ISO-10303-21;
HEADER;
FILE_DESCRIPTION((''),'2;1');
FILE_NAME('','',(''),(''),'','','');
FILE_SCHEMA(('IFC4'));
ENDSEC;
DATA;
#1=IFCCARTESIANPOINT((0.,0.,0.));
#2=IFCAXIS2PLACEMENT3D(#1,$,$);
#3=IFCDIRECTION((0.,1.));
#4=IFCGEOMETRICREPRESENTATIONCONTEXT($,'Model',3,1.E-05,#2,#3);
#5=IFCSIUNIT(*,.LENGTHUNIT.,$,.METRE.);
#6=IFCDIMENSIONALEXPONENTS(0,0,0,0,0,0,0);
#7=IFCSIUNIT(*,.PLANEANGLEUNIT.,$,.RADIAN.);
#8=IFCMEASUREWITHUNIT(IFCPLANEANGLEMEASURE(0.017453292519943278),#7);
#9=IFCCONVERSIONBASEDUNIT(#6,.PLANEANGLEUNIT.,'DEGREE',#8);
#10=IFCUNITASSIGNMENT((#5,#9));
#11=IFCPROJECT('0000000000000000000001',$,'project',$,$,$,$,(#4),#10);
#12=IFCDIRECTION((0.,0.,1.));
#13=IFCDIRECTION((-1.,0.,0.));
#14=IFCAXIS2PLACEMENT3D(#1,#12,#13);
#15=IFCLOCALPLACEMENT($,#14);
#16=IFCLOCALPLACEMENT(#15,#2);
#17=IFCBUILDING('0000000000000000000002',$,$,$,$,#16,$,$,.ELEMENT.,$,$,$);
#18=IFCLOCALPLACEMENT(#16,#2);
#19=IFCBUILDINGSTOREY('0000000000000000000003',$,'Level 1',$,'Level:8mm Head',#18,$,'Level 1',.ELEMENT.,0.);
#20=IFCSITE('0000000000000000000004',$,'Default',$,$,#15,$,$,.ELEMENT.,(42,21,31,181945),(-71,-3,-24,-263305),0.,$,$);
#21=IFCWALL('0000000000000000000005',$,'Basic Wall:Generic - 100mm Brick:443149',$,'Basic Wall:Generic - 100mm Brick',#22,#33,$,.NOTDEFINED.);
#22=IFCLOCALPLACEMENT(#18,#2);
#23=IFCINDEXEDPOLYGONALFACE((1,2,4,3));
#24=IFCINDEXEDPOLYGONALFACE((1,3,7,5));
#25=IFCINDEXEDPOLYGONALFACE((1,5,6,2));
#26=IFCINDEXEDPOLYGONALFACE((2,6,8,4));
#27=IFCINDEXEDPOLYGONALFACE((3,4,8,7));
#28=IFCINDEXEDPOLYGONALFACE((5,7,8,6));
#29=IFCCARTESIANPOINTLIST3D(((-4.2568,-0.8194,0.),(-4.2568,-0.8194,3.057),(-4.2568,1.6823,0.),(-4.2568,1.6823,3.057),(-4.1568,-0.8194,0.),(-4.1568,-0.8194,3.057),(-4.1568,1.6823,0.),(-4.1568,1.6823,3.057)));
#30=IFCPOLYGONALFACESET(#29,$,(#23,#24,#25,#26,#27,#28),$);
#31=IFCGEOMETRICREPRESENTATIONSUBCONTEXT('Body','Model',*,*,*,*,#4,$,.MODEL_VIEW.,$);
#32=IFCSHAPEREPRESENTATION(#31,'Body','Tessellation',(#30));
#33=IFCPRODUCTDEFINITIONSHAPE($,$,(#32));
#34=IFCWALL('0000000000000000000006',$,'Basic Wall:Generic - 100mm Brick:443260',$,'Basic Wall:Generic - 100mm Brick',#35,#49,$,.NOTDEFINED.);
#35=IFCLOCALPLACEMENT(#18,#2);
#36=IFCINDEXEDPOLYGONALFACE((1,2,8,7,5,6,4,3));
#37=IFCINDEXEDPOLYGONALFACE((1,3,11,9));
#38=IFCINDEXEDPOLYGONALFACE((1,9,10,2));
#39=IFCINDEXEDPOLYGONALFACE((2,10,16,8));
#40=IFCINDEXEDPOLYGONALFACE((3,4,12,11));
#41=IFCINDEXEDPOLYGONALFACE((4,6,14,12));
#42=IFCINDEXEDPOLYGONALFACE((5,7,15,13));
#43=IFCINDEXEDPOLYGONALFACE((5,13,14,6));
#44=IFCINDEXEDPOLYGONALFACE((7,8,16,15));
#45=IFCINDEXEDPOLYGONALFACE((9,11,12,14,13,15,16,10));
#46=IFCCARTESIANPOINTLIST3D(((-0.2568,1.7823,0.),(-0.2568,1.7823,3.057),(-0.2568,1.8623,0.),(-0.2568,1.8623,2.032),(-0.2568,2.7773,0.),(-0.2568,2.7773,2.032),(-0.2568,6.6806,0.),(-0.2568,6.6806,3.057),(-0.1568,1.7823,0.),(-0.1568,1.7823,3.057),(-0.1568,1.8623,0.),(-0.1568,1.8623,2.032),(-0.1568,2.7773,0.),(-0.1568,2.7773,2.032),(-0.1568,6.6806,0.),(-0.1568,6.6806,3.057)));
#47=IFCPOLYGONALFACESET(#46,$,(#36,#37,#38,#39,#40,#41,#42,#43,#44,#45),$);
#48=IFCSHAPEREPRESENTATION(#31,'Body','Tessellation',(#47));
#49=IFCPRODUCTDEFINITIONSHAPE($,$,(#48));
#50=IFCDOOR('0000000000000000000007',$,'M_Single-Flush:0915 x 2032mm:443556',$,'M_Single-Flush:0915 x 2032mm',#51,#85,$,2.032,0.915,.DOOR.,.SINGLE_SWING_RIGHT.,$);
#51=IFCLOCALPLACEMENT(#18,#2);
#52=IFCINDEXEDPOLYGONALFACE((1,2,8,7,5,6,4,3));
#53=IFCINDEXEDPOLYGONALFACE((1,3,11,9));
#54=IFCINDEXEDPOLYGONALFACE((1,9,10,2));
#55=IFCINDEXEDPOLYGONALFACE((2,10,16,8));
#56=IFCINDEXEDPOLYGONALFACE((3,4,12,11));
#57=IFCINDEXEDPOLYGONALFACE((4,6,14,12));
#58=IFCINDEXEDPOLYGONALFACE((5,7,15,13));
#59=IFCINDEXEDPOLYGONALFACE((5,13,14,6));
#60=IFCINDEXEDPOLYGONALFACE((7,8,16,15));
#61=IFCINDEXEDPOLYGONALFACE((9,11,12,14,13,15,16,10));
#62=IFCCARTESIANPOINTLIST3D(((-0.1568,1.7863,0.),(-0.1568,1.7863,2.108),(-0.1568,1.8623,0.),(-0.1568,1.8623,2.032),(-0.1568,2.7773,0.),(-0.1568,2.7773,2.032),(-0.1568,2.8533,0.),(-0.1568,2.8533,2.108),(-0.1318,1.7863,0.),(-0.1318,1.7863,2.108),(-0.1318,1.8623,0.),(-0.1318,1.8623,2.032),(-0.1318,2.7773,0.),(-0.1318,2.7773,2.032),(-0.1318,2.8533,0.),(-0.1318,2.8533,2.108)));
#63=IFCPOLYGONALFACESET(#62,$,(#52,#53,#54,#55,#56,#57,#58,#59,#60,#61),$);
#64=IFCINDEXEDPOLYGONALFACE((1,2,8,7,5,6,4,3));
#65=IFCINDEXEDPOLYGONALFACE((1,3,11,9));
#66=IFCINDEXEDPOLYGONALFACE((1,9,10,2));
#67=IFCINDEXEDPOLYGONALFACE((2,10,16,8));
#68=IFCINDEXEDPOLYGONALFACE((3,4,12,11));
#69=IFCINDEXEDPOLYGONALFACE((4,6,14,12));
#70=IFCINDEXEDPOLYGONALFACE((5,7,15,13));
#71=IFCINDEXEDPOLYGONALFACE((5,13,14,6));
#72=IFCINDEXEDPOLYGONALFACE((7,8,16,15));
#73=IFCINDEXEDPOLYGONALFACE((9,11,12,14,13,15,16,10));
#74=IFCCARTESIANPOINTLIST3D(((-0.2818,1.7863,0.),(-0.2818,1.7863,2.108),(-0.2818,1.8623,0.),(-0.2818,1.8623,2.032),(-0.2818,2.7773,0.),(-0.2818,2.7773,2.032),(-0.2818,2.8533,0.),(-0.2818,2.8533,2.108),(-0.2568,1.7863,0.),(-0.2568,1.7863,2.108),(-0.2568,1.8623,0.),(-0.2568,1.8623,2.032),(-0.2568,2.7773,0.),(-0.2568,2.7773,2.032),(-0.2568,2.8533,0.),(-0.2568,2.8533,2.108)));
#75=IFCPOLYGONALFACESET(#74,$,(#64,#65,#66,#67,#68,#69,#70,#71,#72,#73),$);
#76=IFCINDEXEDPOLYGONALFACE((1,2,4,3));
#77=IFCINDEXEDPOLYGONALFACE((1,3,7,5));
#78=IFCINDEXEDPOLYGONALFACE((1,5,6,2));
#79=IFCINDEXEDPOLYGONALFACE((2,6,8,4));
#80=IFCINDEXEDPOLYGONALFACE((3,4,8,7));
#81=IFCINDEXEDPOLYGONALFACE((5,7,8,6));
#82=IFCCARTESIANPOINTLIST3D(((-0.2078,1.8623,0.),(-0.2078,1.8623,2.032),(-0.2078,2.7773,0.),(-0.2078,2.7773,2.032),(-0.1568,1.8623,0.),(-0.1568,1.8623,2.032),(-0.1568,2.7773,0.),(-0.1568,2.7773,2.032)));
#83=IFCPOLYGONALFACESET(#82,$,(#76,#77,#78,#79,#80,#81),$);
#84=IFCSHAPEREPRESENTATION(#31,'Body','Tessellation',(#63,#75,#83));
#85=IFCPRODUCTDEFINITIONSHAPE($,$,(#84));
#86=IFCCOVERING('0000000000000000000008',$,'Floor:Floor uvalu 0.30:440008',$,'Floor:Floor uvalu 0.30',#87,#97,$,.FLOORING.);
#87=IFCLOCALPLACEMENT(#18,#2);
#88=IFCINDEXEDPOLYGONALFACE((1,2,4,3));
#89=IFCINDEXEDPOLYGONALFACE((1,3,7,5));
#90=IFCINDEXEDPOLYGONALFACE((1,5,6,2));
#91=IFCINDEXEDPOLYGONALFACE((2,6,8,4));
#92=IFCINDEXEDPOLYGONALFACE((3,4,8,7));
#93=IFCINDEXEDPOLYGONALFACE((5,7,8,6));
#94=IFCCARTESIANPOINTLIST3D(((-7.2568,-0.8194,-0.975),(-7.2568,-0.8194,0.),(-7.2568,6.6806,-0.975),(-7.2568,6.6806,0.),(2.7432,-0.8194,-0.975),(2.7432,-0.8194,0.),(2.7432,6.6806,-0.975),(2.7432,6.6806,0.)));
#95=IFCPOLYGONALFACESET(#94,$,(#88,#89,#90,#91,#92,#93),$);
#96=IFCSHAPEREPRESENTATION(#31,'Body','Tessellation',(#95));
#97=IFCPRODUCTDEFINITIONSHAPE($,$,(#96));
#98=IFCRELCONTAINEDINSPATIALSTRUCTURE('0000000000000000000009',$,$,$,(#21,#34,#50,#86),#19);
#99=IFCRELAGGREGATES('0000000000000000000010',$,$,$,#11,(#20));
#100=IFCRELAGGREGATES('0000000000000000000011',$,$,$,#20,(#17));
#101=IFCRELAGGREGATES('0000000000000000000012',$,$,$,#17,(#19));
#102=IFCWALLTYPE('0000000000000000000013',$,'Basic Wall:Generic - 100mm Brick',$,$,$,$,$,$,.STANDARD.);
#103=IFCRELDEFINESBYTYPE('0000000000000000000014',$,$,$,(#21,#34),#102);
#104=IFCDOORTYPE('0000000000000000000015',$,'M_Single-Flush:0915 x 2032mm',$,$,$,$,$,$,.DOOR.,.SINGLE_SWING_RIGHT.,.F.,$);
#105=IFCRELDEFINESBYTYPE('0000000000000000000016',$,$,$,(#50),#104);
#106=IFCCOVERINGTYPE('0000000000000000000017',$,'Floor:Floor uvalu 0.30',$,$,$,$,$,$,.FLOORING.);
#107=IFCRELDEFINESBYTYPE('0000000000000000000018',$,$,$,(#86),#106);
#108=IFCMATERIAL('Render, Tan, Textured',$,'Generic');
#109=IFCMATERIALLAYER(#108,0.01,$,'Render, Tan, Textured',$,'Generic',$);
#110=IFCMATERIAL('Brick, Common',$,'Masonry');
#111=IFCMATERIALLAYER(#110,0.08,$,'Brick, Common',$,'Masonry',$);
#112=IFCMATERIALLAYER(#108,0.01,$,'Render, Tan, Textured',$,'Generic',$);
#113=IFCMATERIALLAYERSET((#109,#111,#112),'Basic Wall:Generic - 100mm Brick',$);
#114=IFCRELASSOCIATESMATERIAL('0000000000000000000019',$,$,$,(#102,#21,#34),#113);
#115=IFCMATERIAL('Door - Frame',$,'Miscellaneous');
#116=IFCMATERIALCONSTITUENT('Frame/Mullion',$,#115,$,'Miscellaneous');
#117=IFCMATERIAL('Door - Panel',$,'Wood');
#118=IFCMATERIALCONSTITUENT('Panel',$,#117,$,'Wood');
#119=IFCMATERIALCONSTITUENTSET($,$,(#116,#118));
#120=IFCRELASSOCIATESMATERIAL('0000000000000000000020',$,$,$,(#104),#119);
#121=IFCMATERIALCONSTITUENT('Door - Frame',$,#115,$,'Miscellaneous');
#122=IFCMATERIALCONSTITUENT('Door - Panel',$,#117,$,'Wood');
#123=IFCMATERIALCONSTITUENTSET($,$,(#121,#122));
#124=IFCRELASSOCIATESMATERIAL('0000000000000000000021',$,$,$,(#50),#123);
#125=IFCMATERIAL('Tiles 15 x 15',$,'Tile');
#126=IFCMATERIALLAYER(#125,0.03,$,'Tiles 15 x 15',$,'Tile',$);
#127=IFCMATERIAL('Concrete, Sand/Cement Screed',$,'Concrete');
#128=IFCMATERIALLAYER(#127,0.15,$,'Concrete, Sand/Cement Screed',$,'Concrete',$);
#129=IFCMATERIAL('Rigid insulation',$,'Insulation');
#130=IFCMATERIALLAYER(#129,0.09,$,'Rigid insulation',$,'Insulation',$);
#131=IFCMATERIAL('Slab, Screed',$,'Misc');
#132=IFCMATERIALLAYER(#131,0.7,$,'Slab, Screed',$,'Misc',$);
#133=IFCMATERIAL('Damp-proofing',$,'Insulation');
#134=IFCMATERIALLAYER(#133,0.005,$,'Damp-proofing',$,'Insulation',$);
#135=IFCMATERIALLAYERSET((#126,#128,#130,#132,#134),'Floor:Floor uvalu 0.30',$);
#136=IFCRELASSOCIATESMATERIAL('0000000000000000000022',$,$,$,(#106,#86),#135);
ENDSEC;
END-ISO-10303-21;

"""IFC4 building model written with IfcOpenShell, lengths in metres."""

from ifc_helpers import new_model, entity, si_unit, converted_unit, direction, frame, frame_2d, origin, origin_2d_with_axis, place, context, subcontext, project, spatial, polyline, rectangle, outline, extrude, source, transform, mapped, material, layer, layer_set, layer_usage, constituent, constituent_set, type_object, type_shapes, element, fill, save


model = new_model("IFC4")

# Units and contexts
model_context = context("Model", 3, precision=1e-05, world=origin(), true_north=direction((0.0, 1.0)))
body_context = subcontext(model_context, "Body", "Model", "MODEL_VIEW")
ifc_project = project(units=[si_unit("LENGTHUNIT", "METRE"), converted_unit("PLANEANGLEUNIT", "DEGREE", entity("IfcPlaneAngleMeasure", 0.017453292519943278), si_unit("PLANEANGLEUNIT", "RADIAN"), dimensions=[0, 0, 0, 0, 0, 0, 0])], contexts=[model_context])

# Site, building, storey
site_placement = place(None, frame((0.0, 0.0, 0.0), z_axis=(0.0, 0.0, 1.0), x_axis=(-1.0, 0.0, 0.0)))
site = spatial("IfcSite", under=ifc_project, at=site_placement, Name="Default", CompositionType="ELEMENT", RefLatitude=(42, 21, 31, 181945), RefLongitude=(-71, -3, -24, -263305), RefElevation=0.0)
building_placement = place(site_placement, origin())
building = spatial("IfcBuilding", under=site, at=building_placement, CompositionType="ELEMENT")
storey_placement = place(building_placement, origin())
storey = spatial("IfcBuildingStorey", under=building, at=storey_placement, Name="Level 1", ObjectType="Level:8mm Head", LongName="Level 1", CompositionType="ELEMENT", Elevation=0.0)

# Shared definitions
ifc_material_1 = material(Name="Rigid insulation", Category="Insulation")
ifc_material_2 = material(Name="Brick, Common", Category="Masonry")

# Shared definitions
ifc_material_3 = material(Name="Render, Tan, Textured", Category="Generic")
ifc_layer_1 = layer(ifc_material_3, 0.01, Name="Render, Tan, Textured", Category="Generic")
ifc_layer_2 = layer(ifc_material_2, 0.08, Name="Brick, Common", Category="Masonry")
ifc_layer_3 = layer(ifc_material_3, 0.01, Name="Render, Tan, Textured", Category="Generic")
ifc_layer_set_1 = layer_set([ifc_layer_1, ifc_layer_2, ifc_layer_3], Name="Basic Wall:Generic - 100mm Brick")
ifc_layer_usage_1 = layer_usage(ifc_layer_set_1, "AXIS2", "NEGATIVE", 0.05)
wall_type_1 = type_object("IfcWallType", Name="Basic Wall:Generic - 100mm Brick", PredefinedType="STANDARD", material=ifc_layer_set_1)
ifc_material_4 = material(Name="Door - Frame", Category="Miscellaneous")
ifc_material_5 = material(Name="Door - Panel", Category="Wood")
ifc_constituent_1 = constituent(ifc_material_4, Name="Frame/Mullion", Category="Miscellaneous")
ifc_constituent_2 = constituent(ifc_material_5, Name="Panel", Category="Wood")
ifc_constituent_set_1 = constituent_set(constituents=[ifc_constituent_1, ifc_constituent_2])
door_type_1 = type_object("IfcDoorType", Name="M_Single-Flush:0915 x 2032mm", OperationType="SINGLE_SWING_RIGHT", ParameterTakesPrecedence=False, PredefinedType="DOOR", material=ifc_constituent_set_1)
shared_shape_1 = source(origin(), body_context, "Body", "SweptSolid", [
    extrude(outline(polyline([(-0.5335, -1.073), (0.5335, -1.073), (0.5335, 1.035), (0.4575, 1.035), (0.4575, -0.997), (-0.4575, -0.997), (-0.4575, 1.035), (-0.5335, 1.035), (-0.5335, -1.073)])), frame((0.4575, 0.1, 1.035), z_axis=(0.0, 1.0, 0.0), x_axis=(1.0, 0.0, 0.0)), (0.0, 0.0, 1.0), 0.025),
    extrude(outline(polyline([(-1.073, -0.5335), (1.035, -0.5335), (1.035, -0.4575), (-0.997, -0.4575), (-0.997, 0.4575), (1.035, 0.4575), (1.035, 0.5335), (-1.073, 0.5335), (-1.073, -0.5335)])), frame((0.4575, -0.025, 1.035), z_axis=(0.0, 1.0, 0.0), x_axis=(0.0, 0.0, -1.0)), (0.0, 0.0, 1.0), 0.025),
    extrude(rectangle(XDim=0.051, YDim=0.915, at=frame_2d((0.0, 0.0), x_axis=(1.0, 0.0))), frame((0.4575, 0.0745, 0.0), z_axis=(0.0, 0.0, 1.0), x_axis=(0.0, 1.0, 0.0)), (0.0, 0.0, 1.0), 2.032),
])
type_shapes(door_type_1, [shared_shape_1])

# Wall
wall_1_placement = place(storey_placement, frame((-4.2068, -0.8194, 0.0), z_axis=(0.0, 0.0, 1.0), x_axis=(0.0, 1.0, 0.0)))
element("IfcWall", 1, at=wall_1_placement, inside=storey, type_object=wall_type_1, material=ifc_layer_usage_1, Name="Basic Wall:Generic - 100mm Brick:443149", ObjectType="Basic Wall:Generic - 100mm Brick", PredefinedType="NOTDEFINED", context=body_context, shape_type="SweptSolid", body=[
    extrude(rectangle(XDim=2.5017, YDim=0.1, at=frame_2d((1.2508, 0.0), x_axis=(-1.0, 0.0))), origin(), (0.0, 0.0, 1.0), 3.057),
])

# Wall, opening, door
wall_2_placement = place(storey_placement, frame((-0.2068, 6.6806, 0.0), z_axis=(0.0, 0.0, 1.0), x_axis=(0.0, -1.0, 0.0)))
wall_2 = element("IfcWall", 2, at=wall_2_placement, inside=storey, type_object=wall_type_1, material=ifc_layer_usage_1, Name="Basic Wall:Generic - 100mm Brick:443260", ObjectType="Basic Wall:Generic - 100mm Brick", PredefinedType="NOTDEFINED", context=body_context, shape_type="SweptSolid", body=[
    extrude(rectangle(XDim=4.8983, YDim=0.1, at=frame_2d((2.4492, 0.0), x_axis=(-1.0, 0.0))), origin(), (0.0, 0.0, 1.0), 3.057),
])
opening_1_placement = place(wall_2_placement, frame((3.9033, -0.05, 0.0)))
opening_1 = element("IfcOpeningElement", 3, at=opening_1_placement, cuts=wall_2, PredefinedType="OPENING", context=body_context, shape_type="SweptSolid", body=[
    extrude(rectangle(XDim=0.915, YDim=2.032, at=frame_2d((1.016, 0.4575), x_axis=(0.0, 1.0))), frame((0.0, 0.0, 0.0), z_axis=(0.0, 1.0, 0.0), x_axis=(0.0, 0.0, 1.0)), (0.0, 0.0, 1.0), 0.1),
])
ifc_constituent_3 = constituent(ifc_material_4, Name="Door - Frame", Category="Miscellaneous")
ifc_constituent_4 = constituent(ifc_material_5, Name="Door - Panel", Category="Wood")
ifc_constituent_set_2 = constituent_set(constituents=[ifc_constituent_3, ifc_constituent_4])
door_1_placement = place(opening_1_placement, origin())
door_1 = element("IfcDoor", 4, at=door_1_placement, inside=storey, type_object=door_type_1, material=ifc_constituent_set_2, Name="M_Single-Flush:0915 x 2032mm:443556", ObjectType="M_Single-Flush:0915 x 2032mm", OperationType="SINGLE_SWING_RIGHT", OverallHeight=2.032, OverallWidth=0.915, PredefinedType="DOOR", context=body_context, shape_type="MappedRepresentation", body=[
    mapped(shared_shape_1, transform((0.0, 0.0, 0.0), scale=1.0)),
])
fill(opening_1, door_1)

# Covering
ifc_material_6 = material(Name="Tiles 15 x 15", Category="Tile")
ifc_layer_4 = layer(ifc_material_6, 0.03, Name="Tiles 15 x 15", Category="Tile")
ifc_material_7 = material(Name="Concrete, Sand/Cement Screed", Category="Concrete")
ifc_layer_5 = layer(ifc_material_7, 0.15, Name="Concrete, Sand/Cement Screed", Category="Concrete")
ifc_layer_6 = layer(ifc_material_1, 0.09, Name="Rigid insulation", Category="Insulation")
ifc_material_8 = material(Name="Slab, Screed", Category="Misc")
ifc_layer_7 = layer(ifc_material_8, 0.7, Name="Slab, Screed", Category="Misc")
ifc_material_9 = material(Name="Damp-proofing", Category="Insulation")
ifc_layer_8 = layer(ifc_material_9, 0.005, Name="Damp-proofing", Category="Insulation")
ifc_layer_set_2 = layer_set([ifc_layer_4, ifc_layer_5, ifc_layer_6, ifc_layer_7, ifc_layer_8], Name="Floor:Floor uvalu 0.30")
ifc_layer_usage_2 = layer_usage(ifc_layer_set_2, "AXIS3", "POSITIVE", 0.0)
covering_type_1 = type_object("IfcCoveringType", Name="Floor:Floor uvalu 0.30", PredefinedType="FLOORING", material=ifc_layer_set_2)
covering_1_placement = place(storey_placement, origin())
element("IfcCovering", 5, at=covering_1_placement, inside=storey, type_object=covering_type_1, material=ifc_layer_usage_2, Name="Floor:Floor uvalu 0.30:440008", ObjectType="Floor:Floor uvalu 0.30", PredefinedType="FLOORING", context=body_context, shape_type="SweptSolid", body=[
    extrude(rectangle(XDim=7.5, YDim=10.0, at=origin_2d_with_axis()), frame((-2.2568, 2.9306, 0.0), z_axis=(0.0, 0.0, -1.0), x_axis=(0.0, 1.0, 0.0)), (0.0, 0.0, 1.0), 0.975),
])

save(model, "model.ifc")
